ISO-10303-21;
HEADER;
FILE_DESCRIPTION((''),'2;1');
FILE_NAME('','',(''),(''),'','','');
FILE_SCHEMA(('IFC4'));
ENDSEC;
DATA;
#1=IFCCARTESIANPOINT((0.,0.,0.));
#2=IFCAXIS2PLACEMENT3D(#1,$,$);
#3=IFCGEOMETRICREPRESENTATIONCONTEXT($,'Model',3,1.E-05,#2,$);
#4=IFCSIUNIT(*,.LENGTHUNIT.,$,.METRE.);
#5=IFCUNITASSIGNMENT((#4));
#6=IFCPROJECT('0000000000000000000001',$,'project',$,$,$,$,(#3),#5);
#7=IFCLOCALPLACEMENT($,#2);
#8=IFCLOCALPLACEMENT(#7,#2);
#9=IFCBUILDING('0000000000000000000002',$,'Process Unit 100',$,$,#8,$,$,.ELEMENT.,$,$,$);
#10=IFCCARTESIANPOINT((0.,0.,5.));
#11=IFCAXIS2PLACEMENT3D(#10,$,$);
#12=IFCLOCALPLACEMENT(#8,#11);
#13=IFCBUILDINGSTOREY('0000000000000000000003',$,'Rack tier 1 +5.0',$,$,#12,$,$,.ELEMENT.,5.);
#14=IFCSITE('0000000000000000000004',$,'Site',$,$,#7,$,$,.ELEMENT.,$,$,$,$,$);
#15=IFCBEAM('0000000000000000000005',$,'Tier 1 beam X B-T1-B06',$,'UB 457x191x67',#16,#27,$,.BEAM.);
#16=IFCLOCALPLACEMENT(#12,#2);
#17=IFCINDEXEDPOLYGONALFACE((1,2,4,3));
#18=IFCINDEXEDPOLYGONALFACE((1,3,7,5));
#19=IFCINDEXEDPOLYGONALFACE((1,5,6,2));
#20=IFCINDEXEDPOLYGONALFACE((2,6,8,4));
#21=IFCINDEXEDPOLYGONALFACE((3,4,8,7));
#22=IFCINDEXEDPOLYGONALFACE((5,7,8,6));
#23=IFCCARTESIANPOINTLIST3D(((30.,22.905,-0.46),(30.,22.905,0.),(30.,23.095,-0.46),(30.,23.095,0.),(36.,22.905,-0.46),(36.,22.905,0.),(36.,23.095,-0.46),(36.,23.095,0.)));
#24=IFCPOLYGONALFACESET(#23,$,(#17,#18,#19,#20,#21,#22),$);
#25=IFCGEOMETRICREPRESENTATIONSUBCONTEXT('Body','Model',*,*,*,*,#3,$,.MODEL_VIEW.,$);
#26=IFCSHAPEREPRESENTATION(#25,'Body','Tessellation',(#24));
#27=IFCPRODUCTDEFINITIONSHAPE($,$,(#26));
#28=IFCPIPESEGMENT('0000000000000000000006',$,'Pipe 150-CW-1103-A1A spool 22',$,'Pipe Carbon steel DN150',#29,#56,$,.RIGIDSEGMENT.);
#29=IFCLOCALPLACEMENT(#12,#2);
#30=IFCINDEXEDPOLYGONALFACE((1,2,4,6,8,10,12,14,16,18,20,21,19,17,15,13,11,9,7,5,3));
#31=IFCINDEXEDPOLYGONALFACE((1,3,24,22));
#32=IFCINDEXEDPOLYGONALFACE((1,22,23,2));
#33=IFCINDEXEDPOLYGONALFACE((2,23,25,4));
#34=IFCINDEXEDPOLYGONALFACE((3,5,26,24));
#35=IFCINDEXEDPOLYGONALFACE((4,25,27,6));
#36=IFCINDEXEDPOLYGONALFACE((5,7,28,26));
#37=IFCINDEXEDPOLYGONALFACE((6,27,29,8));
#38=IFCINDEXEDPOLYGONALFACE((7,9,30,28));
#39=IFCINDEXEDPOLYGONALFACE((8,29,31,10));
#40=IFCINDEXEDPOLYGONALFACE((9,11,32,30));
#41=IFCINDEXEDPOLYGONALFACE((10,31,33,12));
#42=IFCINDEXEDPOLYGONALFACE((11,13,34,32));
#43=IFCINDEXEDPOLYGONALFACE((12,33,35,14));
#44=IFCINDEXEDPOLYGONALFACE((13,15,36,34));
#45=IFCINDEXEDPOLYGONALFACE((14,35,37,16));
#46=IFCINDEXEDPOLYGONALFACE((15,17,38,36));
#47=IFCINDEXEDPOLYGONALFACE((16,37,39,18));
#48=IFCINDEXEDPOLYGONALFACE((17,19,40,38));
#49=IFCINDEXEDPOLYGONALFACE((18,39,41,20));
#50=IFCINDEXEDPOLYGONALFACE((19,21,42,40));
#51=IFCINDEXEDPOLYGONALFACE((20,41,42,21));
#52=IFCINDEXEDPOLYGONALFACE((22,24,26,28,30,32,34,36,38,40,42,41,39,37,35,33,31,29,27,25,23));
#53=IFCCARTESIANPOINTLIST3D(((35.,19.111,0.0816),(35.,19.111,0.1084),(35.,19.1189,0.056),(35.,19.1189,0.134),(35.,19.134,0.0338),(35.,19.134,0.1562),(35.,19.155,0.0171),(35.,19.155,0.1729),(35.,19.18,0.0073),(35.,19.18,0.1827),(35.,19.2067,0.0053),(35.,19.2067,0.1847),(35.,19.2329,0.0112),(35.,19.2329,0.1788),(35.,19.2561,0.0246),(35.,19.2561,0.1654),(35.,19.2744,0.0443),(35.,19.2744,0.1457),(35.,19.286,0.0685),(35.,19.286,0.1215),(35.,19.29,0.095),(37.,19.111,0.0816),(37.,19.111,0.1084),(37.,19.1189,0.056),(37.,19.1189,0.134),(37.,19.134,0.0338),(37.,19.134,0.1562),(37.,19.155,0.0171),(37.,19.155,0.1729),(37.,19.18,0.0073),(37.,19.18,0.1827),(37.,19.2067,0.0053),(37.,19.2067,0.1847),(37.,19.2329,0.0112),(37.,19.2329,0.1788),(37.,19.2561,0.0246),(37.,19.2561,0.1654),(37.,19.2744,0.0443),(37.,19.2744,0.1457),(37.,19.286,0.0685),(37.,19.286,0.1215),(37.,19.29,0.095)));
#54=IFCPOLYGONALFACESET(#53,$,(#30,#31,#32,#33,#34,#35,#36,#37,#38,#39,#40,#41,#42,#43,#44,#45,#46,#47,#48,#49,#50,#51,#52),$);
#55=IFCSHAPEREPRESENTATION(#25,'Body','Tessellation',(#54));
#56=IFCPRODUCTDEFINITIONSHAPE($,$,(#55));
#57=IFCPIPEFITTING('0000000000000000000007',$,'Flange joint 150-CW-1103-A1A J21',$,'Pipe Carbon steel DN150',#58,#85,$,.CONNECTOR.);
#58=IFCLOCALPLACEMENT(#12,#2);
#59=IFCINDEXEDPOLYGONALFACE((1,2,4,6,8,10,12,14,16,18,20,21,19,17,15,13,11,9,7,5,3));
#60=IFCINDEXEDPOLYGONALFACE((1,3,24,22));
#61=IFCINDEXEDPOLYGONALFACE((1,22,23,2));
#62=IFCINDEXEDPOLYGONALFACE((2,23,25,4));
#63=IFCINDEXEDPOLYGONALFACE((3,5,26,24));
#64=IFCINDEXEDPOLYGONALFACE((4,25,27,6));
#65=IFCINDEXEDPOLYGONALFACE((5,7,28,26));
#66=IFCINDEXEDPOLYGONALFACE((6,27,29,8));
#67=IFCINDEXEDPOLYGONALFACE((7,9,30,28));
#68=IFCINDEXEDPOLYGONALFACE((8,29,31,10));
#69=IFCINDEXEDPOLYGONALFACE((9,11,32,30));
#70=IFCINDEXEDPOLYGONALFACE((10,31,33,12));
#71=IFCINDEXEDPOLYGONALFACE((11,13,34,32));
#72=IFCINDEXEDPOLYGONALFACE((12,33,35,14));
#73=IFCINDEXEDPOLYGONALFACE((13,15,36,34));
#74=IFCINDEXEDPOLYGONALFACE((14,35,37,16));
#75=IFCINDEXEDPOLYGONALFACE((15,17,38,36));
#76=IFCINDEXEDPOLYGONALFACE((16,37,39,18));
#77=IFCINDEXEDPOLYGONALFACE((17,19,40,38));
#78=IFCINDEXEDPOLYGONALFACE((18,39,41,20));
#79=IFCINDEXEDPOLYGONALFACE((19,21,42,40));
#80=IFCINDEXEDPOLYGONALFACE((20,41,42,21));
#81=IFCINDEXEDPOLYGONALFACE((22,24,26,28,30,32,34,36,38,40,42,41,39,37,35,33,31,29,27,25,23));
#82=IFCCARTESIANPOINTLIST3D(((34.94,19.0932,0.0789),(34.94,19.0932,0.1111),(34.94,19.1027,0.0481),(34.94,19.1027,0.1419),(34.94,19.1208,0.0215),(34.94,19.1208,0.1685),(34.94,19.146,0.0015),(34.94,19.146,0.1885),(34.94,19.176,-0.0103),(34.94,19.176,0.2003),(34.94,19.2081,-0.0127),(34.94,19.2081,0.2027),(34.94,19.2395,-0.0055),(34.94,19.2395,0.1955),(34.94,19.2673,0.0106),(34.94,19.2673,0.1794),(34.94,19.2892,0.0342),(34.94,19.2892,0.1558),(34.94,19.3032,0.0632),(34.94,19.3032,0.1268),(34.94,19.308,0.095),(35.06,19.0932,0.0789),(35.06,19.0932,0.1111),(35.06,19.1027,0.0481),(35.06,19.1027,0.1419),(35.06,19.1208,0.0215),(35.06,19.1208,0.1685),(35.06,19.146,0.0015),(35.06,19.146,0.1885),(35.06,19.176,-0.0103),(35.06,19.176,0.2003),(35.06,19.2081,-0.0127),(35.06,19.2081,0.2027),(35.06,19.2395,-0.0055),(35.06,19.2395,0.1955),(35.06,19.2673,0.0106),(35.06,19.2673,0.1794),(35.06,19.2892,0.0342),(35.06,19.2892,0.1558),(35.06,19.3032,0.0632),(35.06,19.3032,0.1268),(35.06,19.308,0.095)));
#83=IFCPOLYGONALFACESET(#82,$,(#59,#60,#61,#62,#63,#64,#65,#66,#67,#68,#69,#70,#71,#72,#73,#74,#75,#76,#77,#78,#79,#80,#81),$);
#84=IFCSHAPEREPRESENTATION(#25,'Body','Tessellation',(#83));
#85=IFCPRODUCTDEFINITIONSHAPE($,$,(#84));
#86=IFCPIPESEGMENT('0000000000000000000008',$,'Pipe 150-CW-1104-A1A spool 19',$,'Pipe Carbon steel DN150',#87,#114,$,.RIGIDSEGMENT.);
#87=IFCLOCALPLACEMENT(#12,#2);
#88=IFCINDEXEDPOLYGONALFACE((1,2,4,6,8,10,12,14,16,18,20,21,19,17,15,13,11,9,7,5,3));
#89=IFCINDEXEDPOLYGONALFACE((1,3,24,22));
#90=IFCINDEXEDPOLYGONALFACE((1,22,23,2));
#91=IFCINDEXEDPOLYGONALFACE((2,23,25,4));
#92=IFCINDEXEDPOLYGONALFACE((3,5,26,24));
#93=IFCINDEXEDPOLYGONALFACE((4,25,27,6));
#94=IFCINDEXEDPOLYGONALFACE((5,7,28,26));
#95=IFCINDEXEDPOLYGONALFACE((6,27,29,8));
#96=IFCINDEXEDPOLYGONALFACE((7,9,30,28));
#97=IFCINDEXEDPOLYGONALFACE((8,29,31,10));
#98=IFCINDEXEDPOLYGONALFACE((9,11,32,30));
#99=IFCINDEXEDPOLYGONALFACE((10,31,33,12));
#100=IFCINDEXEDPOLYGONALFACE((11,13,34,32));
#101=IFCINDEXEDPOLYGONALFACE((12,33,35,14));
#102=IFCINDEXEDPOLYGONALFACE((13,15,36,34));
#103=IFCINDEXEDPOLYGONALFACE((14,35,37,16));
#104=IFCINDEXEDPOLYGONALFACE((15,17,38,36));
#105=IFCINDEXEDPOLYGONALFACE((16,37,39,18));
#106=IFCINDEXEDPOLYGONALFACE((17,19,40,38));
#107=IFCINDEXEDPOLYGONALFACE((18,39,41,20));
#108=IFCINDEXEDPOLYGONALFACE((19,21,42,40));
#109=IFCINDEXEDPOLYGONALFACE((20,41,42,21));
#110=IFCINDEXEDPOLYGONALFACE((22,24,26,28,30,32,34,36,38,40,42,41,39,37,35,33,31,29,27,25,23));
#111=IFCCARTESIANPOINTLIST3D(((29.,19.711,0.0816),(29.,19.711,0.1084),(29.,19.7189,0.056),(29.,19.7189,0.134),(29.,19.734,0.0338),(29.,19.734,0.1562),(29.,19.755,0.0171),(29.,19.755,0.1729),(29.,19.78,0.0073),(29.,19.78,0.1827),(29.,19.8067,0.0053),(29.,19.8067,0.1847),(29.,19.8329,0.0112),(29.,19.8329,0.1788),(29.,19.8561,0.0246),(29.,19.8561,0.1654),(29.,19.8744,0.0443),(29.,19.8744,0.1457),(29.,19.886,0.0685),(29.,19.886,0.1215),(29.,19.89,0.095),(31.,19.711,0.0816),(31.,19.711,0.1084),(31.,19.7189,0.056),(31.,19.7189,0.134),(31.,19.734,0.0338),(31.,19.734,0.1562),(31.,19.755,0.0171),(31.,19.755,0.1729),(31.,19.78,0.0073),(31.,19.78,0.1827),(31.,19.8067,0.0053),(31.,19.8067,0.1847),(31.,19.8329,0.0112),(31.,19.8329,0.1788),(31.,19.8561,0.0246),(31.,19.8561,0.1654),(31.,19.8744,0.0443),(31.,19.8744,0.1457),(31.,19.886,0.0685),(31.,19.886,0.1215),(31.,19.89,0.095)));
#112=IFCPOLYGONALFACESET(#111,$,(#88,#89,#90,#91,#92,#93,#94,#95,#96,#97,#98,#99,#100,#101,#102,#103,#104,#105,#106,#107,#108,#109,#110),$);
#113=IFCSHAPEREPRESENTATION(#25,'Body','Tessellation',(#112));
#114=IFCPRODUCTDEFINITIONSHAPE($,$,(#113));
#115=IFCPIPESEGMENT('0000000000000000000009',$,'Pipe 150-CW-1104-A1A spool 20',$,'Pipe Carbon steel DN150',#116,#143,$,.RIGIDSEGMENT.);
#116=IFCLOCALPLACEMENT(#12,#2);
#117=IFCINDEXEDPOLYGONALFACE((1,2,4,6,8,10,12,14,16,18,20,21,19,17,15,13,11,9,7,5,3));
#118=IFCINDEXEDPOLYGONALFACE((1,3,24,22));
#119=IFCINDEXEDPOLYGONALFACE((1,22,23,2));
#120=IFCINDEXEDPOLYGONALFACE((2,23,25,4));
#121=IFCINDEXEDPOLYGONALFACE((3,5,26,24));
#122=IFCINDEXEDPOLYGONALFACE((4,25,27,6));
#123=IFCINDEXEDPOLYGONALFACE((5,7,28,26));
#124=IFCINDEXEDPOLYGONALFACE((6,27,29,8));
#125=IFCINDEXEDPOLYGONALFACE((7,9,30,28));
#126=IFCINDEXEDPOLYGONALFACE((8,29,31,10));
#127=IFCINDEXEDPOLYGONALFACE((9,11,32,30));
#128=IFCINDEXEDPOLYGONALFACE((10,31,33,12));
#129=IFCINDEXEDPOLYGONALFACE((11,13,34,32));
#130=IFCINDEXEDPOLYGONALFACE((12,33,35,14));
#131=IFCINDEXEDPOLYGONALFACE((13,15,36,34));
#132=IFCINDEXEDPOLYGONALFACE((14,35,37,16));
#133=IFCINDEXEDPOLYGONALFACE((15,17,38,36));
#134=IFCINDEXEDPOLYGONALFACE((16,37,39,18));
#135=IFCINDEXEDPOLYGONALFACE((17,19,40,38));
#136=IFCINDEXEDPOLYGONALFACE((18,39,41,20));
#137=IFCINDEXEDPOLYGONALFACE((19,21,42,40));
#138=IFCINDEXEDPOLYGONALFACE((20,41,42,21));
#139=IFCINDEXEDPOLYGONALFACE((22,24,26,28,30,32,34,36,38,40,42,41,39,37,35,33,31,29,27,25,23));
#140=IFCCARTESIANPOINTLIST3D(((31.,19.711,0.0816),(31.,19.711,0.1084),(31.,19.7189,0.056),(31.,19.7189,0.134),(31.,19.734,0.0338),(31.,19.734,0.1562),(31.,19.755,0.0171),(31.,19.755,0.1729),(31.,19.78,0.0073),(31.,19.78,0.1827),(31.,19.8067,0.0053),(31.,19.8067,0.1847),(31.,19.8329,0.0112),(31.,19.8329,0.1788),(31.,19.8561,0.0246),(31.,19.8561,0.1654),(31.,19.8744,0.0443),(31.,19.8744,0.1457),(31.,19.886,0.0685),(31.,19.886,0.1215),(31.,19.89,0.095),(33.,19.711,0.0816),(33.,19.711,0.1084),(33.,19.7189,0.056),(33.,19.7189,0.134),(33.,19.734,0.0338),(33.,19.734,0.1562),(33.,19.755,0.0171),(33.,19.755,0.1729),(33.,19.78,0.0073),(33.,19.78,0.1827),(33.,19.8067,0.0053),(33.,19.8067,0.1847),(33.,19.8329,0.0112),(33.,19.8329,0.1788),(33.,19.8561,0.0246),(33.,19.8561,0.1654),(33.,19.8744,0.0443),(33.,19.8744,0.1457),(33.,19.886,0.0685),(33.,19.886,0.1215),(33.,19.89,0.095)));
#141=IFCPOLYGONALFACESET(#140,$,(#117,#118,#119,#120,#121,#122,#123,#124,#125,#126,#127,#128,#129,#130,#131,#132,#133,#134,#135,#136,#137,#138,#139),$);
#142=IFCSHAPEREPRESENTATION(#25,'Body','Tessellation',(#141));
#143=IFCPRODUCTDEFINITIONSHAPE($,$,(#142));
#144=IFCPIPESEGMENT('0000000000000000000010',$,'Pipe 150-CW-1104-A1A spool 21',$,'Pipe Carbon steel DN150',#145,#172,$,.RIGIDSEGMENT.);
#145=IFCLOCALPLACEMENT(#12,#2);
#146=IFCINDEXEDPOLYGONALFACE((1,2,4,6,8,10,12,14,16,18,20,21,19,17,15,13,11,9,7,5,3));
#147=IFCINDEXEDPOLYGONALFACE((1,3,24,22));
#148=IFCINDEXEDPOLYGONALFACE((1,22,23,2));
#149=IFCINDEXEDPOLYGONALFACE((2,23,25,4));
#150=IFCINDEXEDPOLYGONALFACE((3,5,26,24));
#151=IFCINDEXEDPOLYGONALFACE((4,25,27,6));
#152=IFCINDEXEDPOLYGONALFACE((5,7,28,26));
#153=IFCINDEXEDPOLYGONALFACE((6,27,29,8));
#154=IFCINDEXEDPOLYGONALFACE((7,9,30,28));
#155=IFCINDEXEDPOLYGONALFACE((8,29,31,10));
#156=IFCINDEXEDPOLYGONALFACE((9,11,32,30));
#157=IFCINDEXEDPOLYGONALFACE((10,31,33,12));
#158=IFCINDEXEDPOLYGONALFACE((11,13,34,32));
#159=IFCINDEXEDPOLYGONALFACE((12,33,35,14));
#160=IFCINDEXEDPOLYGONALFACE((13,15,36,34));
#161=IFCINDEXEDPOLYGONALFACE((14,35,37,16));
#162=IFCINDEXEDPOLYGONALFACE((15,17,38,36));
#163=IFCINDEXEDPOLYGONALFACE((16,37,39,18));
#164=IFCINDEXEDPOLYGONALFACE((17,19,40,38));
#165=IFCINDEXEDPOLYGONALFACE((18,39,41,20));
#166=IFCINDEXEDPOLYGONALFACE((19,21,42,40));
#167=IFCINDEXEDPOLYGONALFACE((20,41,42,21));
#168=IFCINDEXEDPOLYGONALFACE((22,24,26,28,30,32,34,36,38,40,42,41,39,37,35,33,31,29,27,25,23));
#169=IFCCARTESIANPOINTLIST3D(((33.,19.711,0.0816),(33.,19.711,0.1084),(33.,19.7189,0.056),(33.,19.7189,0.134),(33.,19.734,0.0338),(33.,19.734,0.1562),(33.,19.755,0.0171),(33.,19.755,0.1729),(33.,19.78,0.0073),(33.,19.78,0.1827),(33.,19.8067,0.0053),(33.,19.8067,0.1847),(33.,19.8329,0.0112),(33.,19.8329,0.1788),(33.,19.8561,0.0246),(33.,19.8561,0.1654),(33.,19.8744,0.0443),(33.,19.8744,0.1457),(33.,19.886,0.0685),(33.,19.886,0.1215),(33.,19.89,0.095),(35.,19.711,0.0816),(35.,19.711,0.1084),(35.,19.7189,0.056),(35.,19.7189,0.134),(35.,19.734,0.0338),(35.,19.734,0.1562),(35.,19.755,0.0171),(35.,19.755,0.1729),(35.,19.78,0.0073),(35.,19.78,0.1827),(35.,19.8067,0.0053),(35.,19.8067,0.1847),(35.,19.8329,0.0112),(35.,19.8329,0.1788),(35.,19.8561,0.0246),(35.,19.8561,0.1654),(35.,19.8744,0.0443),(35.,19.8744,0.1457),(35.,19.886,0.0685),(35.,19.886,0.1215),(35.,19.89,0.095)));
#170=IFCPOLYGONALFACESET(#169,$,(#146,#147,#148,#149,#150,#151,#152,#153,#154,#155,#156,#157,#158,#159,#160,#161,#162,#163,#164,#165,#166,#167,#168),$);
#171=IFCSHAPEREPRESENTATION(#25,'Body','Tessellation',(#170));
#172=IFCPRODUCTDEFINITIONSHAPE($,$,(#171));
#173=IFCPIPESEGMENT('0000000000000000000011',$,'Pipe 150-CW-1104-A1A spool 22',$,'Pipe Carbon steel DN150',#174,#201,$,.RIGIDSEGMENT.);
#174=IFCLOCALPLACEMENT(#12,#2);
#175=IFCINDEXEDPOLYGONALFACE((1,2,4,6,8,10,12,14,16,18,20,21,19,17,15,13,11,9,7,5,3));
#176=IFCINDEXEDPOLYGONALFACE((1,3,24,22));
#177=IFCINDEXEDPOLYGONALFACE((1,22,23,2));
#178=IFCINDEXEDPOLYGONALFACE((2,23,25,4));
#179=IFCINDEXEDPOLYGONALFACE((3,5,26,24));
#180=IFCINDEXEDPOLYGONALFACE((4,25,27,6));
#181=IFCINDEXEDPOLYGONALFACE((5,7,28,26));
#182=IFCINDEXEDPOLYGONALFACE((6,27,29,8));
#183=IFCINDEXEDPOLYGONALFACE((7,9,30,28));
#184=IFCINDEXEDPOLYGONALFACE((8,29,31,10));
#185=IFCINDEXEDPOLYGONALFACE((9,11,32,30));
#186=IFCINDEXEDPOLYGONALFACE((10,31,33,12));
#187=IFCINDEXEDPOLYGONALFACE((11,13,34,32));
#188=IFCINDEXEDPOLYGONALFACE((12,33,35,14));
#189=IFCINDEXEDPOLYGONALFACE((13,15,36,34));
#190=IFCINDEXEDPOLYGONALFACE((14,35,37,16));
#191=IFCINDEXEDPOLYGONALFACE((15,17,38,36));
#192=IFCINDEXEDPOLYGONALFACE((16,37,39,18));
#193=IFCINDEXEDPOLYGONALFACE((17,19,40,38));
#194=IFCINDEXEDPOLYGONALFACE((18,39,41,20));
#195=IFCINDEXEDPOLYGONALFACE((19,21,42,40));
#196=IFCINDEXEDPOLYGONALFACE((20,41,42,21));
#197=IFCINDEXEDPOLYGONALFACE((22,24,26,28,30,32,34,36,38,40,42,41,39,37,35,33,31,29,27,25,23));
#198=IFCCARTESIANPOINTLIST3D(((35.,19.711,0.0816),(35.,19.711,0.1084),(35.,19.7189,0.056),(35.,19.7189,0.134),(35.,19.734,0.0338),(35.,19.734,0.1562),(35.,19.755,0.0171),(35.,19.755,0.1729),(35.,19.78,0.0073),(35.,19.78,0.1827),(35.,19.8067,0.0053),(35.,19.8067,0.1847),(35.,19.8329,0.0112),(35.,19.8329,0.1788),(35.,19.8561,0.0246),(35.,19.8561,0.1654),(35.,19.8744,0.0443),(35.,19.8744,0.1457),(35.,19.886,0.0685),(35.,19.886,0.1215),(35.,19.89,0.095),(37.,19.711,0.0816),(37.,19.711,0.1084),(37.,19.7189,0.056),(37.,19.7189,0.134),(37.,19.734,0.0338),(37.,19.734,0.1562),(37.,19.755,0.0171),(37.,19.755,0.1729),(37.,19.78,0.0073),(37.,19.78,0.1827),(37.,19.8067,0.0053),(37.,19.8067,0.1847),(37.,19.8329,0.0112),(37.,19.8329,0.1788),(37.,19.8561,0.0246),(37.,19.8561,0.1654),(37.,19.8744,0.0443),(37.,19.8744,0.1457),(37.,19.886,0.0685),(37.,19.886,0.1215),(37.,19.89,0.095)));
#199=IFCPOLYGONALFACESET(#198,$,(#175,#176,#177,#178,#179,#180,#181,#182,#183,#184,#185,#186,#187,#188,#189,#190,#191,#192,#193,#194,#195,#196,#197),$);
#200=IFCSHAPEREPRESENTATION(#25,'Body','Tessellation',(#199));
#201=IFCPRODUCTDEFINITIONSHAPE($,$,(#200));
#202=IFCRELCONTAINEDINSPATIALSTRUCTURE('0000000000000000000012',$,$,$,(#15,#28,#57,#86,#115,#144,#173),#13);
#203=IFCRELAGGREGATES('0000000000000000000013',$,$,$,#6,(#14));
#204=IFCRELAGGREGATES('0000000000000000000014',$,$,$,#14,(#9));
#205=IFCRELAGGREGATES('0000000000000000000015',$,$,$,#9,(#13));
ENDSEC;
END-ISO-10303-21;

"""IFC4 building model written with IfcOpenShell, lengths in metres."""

from ifc_helpers import new_model, si_unit, frame, origin, place, context, subcontext, project, spatial, rectangle, circle, extrude, element, save


model = new_model("IFC4")

# Units and contexts
model_context = context("Model", 3, precision=1e-05, world=origin())
body_context = subcontext(model_context, "Body", "Model", "MODEL_VIEW")
ifc_project = project(units=[si_unit("LENGTHUNIT", "METRE")], contexts=[model_context])

# Site, building, storey
site_placement = place(None, origin())
site = spatial("IfcSite", under=ifc_project, at=site_placement, Name="Site", CompositionType="ELEMENT")
building_placement = place(site_placement, origin())
building = spatial("IfcBuilding", under=site, at=building_placement, Name="Process Unit 100", CompositionType="ELEMENT")
storey_placement = place(building_placement, frame((0.0, 0.0, 5.0)))
storey = spatial("IfcBuildingStorey", under=building, at=storey_placement, Name="Rack tier 1 +5.0", CompositionType="ELEMENT", Elevation=5.0)

# Beam
beam_placement = place(storey_placement, frame((30.0, 23.0, -0.23), z_axis=(1.0, 0.0, 0.0), x_axis=(0.0, 1.0, 0.0)))
element("IfcBeam", 1, at=beam_placement, inside=storey, Name="Tier 1 beam X B-T1-B06", ObjectType="UB 457x191x67", PredefinedType="BEAM", context=body_context, shape_type="SweptSolid", body=[
    extrude(rectangle(XDim=0.19, YDim=0.46), origin(), (0.0, 0.0, 1.0), 6.0),
])

# Pipe segment
pipe_segment_placement = place(storey_placement, frame((35.0, 19.2, 0.095), z_axis=(1.0, 0.0, 0.0), x_axis=(0.0, 1.0, 0.0)))
element("IfcPipeSegment", 2, at=pipe_segment_placement, inside=storey, Name="Pipe 150-CW-1103-A1A spool 22", ObjectType="Pipe Carbon steel DN150", PredefinedType="RIGIDSEGMENT", context=body_context, shape_type="SweptSolid", body=[
    extrude(circle(Radius=0.09), origin(), (0.0, 0.0, 1.0), 2.0),
])

# Pipe fitting
pipe_fitting_placement = place(storey_placement, frame((34.94, 19.2, 0.095), z_axis=(1.0, 0.0, 0.0), x_axis=(0.0, 1.0, 0.0)))
element("IfcPipeFitting", 3, at=pipe_fitting_placement, inside=storey, Name="Flange joint 150-CW-1103-A1A J21", ObjectType="Pipe Carbon steel DN150", PredefinedType="CONNECTOR", context=body_context, shape_type="SweptSolid", body=[
    extrude(circle(Radius=0.108), origin(), (0.0, 0.0, 1.0), 0.12),
])

# Pipe segments
for number, where, z_axis, x_axis, name in (
    (4, (29.0, 19.8, 0.095), (1.0, 0.0, 0.0), (0.0, 1.0, 0.0), "Pipe 150-CW-1104-A1A spool 19"),
    (5, (31.0, 19.8, 0.095), (1.0, 0.0, 0.0), (0.0, 1.0, 0.0), "Pipe 150-CW-1104-A1A spool 20"),
    (6, (33.0, 19.8, 0.095), (1.0, 0.0, 0.0), (0.0, 1.0, 0.0), "Pipe 150-CW-1104-A1A spool 21"),
    (7, (35.0, 19.8, 0.095), (1.0, 0.0, 0.0), (0.0, 1.0, 0.0), "Pipe 150-CW-1104-A1A spool 22"),
):
    element("IfcPipeSegment", number, at=place(storey_placement, frame(where, z_axis=z_axis, x_axis=x_axis)), inside=storey, Name=name, ObjectType="Pipe Carbon steel DN150", PredefinedType="RIGIDSEGMENT", context=body_context, shape_type="SweptSolid", body=[
        extrude(circle(Radius=0.09), origin(), (0.0, 0.0, 1.0), 2.0),
    ])

save(model, "model.ifc")
